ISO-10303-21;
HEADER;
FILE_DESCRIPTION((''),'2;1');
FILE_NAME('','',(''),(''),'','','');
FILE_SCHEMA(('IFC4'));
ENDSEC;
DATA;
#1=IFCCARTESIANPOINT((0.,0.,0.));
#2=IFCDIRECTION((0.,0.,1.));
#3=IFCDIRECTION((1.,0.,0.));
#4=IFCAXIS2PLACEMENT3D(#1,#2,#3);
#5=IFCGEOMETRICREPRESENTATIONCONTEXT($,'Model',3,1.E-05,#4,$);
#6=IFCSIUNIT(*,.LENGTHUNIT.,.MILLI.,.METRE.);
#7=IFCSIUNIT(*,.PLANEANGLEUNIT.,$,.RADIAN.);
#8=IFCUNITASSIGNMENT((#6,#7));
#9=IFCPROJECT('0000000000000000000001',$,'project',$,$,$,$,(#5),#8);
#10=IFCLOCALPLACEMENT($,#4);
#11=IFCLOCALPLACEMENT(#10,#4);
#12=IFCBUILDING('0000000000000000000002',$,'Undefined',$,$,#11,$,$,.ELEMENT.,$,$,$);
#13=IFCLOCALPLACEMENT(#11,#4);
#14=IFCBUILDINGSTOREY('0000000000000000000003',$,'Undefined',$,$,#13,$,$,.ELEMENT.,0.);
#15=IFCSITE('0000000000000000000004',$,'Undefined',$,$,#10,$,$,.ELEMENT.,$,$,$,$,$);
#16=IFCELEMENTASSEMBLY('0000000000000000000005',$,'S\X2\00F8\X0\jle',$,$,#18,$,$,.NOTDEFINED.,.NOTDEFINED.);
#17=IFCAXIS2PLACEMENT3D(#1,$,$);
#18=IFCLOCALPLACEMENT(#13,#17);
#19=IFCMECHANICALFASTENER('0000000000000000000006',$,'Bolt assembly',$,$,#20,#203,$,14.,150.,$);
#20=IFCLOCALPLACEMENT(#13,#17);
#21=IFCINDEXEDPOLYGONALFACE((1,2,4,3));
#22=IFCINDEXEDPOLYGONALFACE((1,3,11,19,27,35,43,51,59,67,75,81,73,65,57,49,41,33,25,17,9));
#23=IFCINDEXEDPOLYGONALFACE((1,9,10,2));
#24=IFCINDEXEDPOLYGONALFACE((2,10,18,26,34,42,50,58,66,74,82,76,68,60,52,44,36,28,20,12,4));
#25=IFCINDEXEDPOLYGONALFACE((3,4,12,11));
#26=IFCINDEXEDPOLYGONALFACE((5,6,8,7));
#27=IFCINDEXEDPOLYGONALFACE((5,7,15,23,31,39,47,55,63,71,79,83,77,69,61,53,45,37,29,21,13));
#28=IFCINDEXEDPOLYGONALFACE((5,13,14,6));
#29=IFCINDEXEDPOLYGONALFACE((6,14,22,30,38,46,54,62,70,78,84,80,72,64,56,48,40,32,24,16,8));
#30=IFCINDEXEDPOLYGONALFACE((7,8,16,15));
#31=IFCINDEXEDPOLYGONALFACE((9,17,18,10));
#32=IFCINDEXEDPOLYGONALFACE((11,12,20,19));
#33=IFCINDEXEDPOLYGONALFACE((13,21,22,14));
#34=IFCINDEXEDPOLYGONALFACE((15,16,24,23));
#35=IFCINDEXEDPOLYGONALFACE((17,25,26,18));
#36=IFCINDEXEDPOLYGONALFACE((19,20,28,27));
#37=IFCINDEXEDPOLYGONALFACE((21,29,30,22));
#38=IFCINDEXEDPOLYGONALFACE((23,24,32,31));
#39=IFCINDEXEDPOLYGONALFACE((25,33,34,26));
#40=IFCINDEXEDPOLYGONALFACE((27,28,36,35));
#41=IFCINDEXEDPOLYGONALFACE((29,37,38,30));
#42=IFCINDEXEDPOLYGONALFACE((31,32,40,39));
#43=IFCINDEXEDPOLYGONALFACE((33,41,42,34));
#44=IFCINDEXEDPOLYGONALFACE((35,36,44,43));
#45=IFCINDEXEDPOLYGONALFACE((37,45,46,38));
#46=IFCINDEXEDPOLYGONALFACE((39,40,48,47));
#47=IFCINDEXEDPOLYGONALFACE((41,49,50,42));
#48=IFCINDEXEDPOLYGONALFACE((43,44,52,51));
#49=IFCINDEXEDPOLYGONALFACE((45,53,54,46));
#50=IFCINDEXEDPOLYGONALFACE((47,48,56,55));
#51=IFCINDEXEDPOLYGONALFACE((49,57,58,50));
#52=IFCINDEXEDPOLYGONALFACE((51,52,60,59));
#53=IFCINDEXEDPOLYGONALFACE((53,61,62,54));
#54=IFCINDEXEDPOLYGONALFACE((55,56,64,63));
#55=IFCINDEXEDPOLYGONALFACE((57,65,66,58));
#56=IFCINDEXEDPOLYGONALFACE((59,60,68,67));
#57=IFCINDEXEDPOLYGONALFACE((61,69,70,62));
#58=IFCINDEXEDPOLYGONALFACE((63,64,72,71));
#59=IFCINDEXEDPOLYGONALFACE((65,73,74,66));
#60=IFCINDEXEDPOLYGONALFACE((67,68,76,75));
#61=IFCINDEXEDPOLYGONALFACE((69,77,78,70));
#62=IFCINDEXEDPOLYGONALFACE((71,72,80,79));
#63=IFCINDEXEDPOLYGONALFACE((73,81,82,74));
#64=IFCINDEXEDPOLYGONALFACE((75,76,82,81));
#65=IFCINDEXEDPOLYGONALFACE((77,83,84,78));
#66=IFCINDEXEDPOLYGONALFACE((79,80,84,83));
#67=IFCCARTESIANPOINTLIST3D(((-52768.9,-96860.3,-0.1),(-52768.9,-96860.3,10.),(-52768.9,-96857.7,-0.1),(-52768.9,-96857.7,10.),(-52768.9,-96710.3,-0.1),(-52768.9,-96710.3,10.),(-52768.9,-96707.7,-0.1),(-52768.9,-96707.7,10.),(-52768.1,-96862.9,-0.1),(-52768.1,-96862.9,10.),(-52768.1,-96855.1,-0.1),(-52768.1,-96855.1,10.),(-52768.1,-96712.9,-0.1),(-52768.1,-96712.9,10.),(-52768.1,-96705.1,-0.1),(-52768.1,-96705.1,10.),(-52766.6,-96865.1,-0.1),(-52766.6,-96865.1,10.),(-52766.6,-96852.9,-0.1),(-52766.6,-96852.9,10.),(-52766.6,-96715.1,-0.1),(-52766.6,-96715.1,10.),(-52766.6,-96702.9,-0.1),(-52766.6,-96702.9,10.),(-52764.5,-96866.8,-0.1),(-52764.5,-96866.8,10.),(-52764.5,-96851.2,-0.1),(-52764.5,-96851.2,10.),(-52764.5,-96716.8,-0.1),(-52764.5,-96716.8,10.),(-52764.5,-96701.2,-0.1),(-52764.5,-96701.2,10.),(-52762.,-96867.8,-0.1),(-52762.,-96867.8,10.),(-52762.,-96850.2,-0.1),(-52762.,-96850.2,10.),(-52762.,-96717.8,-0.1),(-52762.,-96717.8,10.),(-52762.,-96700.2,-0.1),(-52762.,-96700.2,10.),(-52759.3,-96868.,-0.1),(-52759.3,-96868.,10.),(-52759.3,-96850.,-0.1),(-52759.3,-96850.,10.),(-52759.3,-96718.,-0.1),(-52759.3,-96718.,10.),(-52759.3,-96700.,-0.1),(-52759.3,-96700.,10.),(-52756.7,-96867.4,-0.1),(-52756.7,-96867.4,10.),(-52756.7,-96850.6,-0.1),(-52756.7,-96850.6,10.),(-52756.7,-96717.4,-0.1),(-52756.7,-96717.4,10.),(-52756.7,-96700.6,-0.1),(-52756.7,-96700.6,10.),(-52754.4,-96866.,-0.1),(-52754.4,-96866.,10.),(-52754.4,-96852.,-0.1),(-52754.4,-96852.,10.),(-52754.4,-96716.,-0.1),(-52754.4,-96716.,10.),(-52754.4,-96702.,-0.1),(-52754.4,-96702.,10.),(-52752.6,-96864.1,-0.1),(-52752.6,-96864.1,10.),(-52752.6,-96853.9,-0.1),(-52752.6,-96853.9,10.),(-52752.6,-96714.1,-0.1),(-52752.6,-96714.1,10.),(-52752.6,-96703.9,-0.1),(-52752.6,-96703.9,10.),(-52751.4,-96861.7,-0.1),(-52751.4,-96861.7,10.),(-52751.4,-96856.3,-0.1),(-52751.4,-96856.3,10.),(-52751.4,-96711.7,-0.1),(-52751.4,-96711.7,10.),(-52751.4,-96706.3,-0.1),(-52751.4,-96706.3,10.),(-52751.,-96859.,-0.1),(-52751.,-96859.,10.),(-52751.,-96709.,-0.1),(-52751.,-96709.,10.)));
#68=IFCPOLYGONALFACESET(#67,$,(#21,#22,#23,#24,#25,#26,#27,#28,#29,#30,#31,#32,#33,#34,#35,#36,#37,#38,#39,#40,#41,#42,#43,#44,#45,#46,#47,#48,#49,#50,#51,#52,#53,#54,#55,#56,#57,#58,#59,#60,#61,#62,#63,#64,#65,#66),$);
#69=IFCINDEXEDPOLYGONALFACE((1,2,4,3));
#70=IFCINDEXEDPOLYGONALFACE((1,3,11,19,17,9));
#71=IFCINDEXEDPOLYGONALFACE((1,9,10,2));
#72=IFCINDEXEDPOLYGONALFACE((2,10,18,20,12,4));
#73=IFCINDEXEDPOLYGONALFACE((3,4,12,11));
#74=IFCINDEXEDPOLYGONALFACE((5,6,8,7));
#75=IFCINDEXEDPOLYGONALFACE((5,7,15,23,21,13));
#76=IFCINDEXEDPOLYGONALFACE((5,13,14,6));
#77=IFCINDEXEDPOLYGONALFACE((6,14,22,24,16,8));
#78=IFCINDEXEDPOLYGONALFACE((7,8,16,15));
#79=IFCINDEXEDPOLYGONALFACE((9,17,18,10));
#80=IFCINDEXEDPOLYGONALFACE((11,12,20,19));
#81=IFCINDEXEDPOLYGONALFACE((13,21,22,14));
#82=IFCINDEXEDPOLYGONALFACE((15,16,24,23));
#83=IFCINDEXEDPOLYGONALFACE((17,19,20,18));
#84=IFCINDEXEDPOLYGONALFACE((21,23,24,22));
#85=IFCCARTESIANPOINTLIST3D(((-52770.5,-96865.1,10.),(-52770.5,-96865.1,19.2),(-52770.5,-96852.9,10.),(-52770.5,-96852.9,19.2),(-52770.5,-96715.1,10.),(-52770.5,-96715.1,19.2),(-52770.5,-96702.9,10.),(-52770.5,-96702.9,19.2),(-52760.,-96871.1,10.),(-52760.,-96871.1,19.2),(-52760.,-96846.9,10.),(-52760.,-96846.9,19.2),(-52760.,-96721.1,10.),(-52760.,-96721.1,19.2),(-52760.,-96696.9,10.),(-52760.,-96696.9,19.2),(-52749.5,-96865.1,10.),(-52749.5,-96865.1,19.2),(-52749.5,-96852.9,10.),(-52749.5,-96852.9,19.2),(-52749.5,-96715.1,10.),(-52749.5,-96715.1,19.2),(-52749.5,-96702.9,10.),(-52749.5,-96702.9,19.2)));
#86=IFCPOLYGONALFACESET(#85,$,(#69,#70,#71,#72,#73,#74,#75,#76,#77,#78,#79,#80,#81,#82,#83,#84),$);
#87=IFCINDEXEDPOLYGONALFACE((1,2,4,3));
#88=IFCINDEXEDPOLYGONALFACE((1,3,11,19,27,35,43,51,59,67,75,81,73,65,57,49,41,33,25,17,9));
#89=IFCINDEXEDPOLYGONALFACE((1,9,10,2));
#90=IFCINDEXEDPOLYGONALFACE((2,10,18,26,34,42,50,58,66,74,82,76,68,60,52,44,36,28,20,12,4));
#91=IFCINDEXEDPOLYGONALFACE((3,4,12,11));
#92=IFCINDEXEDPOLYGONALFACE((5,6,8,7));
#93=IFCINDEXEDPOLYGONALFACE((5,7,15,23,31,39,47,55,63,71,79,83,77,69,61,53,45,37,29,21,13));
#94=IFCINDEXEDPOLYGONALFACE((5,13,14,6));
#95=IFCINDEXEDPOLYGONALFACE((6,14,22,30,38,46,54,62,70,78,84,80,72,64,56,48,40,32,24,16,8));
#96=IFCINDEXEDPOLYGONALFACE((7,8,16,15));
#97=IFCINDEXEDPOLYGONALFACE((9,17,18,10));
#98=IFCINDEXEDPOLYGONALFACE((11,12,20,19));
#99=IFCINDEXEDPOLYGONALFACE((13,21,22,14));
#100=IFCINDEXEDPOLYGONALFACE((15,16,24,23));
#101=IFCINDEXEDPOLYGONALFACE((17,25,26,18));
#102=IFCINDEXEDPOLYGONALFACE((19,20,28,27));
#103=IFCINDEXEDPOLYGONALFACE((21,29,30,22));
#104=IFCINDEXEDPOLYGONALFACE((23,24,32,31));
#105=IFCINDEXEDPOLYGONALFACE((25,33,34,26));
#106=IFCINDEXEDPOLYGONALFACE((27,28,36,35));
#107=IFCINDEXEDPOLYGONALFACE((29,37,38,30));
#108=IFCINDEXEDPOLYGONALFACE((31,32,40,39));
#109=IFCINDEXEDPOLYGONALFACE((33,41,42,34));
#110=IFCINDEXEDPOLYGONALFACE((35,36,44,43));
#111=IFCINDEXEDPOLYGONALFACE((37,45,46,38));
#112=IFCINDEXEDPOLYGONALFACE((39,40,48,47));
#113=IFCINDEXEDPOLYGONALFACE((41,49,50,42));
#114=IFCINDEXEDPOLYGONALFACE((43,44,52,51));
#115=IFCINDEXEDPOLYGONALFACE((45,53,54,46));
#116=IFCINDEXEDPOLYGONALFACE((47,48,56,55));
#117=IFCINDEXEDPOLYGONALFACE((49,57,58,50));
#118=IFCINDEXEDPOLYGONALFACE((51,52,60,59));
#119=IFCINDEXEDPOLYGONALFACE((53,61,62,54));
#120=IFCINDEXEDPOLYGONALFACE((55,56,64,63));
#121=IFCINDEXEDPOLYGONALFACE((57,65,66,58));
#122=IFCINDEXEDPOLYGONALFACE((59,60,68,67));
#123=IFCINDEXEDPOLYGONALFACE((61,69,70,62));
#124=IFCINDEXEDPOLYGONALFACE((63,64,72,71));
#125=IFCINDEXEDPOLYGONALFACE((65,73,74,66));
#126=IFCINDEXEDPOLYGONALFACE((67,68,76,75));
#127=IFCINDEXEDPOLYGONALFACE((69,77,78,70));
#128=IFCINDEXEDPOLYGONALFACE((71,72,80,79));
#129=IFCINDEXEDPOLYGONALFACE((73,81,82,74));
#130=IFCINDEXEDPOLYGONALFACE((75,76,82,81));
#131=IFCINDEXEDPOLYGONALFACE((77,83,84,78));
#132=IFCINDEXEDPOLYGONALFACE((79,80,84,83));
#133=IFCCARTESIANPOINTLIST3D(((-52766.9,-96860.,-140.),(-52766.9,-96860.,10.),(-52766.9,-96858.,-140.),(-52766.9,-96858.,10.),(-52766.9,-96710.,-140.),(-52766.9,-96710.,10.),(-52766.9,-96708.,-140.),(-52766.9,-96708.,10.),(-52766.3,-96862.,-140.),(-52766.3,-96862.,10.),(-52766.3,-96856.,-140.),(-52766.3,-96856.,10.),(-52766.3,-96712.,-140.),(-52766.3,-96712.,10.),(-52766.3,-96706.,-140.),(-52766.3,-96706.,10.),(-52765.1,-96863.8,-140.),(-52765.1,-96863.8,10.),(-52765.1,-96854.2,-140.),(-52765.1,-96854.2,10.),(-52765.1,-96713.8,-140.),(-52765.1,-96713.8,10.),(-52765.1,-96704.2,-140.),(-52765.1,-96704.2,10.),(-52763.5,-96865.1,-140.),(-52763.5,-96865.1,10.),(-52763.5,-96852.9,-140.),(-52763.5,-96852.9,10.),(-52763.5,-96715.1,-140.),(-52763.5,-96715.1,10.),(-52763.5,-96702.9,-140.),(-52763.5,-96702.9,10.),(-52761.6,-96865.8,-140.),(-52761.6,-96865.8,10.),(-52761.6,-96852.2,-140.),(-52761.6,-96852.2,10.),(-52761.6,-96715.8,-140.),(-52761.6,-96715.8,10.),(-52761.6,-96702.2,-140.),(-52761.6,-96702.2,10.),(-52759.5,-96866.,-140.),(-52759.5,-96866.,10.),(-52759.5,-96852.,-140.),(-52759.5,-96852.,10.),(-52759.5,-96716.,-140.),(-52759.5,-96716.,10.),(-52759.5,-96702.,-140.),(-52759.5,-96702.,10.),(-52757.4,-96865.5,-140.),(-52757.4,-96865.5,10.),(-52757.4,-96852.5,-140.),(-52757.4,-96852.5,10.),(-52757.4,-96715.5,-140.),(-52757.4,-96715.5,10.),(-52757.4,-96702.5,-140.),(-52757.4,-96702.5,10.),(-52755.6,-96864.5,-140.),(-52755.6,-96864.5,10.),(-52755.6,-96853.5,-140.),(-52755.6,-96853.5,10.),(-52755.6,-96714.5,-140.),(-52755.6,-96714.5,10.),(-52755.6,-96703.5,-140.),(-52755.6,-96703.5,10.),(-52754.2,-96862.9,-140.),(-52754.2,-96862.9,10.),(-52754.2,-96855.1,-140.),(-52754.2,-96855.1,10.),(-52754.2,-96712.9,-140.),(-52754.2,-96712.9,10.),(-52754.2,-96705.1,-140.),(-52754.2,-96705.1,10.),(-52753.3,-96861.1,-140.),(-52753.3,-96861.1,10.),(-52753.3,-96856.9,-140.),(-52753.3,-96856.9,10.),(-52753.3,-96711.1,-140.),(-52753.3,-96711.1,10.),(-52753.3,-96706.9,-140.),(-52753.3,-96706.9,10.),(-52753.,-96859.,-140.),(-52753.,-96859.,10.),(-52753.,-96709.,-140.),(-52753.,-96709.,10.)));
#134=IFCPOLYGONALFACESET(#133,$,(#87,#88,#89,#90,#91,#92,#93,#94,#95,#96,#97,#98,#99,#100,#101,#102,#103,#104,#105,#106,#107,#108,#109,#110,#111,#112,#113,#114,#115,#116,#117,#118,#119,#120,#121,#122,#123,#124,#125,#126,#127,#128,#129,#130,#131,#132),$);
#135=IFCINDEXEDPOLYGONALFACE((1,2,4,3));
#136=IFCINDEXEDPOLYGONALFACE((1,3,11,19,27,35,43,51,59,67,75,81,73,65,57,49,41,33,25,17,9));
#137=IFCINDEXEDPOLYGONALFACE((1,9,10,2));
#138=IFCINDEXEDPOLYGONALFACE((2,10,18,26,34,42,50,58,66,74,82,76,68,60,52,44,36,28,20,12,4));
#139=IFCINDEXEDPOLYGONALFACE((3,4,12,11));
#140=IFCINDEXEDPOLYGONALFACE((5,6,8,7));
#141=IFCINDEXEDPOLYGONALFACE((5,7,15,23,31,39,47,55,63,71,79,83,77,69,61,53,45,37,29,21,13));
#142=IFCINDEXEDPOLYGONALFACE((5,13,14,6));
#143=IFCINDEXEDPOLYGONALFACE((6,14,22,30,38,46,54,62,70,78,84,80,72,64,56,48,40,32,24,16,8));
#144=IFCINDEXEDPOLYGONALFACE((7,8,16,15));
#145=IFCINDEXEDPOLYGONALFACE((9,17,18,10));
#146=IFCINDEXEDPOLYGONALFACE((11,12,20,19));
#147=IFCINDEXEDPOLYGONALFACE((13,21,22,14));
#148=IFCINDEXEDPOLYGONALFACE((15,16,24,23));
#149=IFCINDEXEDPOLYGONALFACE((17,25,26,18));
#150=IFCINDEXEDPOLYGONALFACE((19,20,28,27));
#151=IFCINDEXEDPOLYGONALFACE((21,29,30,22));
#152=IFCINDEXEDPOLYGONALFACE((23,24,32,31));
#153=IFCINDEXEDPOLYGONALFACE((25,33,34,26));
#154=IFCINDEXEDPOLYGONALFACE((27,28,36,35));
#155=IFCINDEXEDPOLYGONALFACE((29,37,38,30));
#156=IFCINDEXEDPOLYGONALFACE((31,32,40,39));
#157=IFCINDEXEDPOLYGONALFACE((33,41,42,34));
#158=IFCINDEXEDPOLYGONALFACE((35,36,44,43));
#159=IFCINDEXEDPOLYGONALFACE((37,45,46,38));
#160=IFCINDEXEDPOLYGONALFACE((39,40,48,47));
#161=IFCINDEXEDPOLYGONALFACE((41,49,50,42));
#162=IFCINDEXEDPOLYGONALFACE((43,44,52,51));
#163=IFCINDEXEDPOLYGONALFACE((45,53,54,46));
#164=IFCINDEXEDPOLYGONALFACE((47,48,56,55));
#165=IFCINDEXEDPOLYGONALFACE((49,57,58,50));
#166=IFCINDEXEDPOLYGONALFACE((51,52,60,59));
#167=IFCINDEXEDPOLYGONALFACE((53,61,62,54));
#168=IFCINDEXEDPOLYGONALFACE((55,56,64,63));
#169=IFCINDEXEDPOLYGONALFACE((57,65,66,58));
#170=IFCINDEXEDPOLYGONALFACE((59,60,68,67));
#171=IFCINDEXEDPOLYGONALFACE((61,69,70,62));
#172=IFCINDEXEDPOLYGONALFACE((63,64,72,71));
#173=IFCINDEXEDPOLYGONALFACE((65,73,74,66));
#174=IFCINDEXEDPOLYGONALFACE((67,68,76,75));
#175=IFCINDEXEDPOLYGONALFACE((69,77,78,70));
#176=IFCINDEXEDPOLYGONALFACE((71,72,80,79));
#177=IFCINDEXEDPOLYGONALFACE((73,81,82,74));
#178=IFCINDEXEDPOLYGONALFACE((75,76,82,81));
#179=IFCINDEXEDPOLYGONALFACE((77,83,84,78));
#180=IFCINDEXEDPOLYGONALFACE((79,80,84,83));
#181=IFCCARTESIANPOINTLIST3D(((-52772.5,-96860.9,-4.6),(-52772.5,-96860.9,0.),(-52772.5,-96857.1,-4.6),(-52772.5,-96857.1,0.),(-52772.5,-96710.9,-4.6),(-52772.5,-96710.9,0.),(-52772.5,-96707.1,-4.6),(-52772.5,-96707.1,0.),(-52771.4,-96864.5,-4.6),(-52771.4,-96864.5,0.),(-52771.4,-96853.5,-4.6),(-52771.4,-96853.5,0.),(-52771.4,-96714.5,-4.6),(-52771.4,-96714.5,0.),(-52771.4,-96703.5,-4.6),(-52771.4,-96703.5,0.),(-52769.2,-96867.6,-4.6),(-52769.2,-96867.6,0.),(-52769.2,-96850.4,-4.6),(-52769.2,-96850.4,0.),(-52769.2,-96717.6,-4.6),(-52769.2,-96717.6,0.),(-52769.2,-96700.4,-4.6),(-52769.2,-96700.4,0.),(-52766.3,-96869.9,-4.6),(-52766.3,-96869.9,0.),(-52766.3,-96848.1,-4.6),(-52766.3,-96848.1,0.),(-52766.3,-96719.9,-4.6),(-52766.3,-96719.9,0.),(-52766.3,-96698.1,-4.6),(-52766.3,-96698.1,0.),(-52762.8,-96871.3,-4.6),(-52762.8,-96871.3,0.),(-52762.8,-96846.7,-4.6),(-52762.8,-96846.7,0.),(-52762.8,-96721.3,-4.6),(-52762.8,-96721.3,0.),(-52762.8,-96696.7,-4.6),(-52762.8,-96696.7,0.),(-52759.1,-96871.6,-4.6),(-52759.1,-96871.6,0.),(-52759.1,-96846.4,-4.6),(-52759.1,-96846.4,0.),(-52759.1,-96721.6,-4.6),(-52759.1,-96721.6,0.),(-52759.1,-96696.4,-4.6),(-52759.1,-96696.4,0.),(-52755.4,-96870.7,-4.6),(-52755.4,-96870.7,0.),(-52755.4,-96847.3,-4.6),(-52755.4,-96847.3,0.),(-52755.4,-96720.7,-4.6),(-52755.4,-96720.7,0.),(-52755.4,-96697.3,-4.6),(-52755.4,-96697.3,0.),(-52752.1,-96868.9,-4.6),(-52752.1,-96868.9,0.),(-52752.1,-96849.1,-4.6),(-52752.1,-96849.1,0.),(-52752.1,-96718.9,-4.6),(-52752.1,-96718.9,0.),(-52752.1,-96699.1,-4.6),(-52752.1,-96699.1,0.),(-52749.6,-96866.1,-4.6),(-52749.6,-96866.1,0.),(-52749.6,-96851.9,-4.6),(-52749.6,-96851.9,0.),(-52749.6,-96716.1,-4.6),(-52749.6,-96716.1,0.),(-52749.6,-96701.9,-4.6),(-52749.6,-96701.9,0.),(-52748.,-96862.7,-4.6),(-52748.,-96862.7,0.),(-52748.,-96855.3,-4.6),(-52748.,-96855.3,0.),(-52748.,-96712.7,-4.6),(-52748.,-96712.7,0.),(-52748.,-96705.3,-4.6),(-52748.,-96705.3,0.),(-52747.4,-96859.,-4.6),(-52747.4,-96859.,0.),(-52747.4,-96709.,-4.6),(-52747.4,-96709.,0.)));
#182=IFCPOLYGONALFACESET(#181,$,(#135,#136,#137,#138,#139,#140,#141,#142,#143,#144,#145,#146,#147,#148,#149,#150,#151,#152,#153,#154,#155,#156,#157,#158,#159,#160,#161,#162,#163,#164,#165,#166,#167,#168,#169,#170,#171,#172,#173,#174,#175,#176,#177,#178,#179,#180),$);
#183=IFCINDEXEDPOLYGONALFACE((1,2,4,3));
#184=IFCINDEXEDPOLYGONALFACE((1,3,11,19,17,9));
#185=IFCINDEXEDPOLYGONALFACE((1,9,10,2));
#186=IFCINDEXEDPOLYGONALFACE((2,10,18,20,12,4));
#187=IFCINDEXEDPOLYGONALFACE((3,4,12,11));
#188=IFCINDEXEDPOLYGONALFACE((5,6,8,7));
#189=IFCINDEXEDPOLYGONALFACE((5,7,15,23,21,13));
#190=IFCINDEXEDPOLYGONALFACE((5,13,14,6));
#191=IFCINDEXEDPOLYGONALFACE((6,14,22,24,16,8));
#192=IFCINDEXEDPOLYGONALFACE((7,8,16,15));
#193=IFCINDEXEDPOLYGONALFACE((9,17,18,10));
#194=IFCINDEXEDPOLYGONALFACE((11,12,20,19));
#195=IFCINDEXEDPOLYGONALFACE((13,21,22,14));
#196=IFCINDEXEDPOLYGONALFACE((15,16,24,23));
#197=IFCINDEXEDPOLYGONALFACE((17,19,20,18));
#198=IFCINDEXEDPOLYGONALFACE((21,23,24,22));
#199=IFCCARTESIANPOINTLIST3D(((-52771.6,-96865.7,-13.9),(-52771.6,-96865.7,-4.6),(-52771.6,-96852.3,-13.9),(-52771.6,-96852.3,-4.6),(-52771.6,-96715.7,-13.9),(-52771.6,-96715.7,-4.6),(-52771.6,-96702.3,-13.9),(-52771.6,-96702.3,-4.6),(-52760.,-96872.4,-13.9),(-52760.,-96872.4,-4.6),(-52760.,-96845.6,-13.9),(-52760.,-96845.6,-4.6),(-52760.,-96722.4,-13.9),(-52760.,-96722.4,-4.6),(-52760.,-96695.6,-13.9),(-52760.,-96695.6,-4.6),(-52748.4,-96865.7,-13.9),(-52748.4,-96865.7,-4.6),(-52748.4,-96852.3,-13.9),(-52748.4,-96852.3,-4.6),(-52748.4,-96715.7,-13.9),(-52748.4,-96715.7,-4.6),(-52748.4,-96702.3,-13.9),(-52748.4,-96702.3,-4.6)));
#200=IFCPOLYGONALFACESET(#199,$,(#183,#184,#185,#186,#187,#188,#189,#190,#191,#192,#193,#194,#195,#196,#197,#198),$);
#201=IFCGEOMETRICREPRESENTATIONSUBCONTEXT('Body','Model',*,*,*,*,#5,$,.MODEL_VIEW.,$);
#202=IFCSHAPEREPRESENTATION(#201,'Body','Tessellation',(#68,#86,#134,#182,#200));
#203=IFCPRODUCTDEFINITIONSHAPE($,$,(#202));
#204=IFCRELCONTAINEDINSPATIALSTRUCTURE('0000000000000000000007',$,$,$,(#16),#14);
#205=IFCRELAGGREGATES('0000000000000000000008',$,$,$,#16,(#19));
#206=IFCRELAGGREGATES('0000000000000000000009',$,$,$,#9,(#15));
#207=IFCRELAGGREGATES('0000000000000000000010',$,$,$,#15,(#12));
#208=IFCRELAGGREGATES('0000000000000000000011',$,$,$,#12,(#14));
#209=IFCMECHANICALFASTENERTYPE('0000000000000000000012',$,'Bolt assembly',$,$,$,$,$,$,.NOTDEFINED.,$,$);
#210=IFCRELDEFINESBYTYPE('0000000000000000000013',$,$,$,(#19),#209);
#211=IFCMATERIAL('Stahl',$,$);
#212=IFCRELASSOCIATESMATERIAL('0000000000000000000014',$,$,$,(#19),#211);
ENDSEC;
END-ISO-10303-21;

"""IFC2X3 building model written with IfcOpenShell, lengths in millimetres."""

from ifc_helpers import new_model, si_unit, frame, origin_with_axes, origin_2d_with_axis, place, context, subcontext, project, spatial, polyline, circle, outline, extrude, source, transform, mapped, material, type_object, element, aggregate, save


model = new_model("IFC2X3")

# Units and contexts
model_context = context("Model", 3, precision=1e-05, world=origin_with_axes())
body_context = subcontext(model_context, "Body", "Model", "MODEL_VIEW")
ifc_project = project(units=[si_unit("LENGTHUNIT", "METRE", prefix="MILLI"), si_unit("PLANEANGLEUNIT", "RADIAN")], contexts=[model_context])

# Site, building, storey
site_placement = place(None, origin_with_axes())
site = spatial("IfcSite", under=ifc_project, at=site_placement, Name="Undefined", CompositionType="ELEMENT")
building_placement = place(site_placement, origin_with_axes())
building = spatial("IfcBuilding", under=site, at=building_placement, Name="Undefined", CompositionType="ELEMENT")
storey_placement = place(building_placement, origin_with_axes())
storey = spatial("IfcBuildingStorey", under=building, at=storey_placement, Name="Undefined", CompositionType="ELEMENT", Elevation=0.0)

# Element assembly
assembly_1_placement = place(storey_placement, origin_with_axes())
assembly_1 = element("IfcElementAssembly", 1, at=assembly_1_placement, inside=storey, Name="Søjle", AssemblyPlace="NOTDEFINED", PredefinedType="NOTDEFINED")

# Shared definitions
mechanical_fastener_type = type_object("IfcMechanicalFastenerType", Name="Bolt assembly")

# Mechanical fastener
ifc_material_1 = material(Name="Stahl")
shared_shape_1 = source(origin_with_axes(), body_context, "Body", "SweptSolid", [
    extrude(circle(Radius=9.0, at=origin_2d_with_axis()), frame((0.0, 0.0, 0.0), z_axis=(0.0, 1.0, 0.0), x_axis=(1.0, 0.0, 0.0)), (0.0, 0.0, 1.0), 10.1),
    extrude(outline(polyline([(10.5, -6.1), (10.5, 6.1), (0.0, 12.1), (-10.5, 6.1), (-10.5, -6.1), (0.0, -12.1), (10.5, -6.1)])), frame((0.0, -9.2, 0.0), z_axis=(0.0, 1.0, 0.0), x_axis=(1.0, 0.0, 0.0)), (0.0, 0.0, 1.0), 9.2),
    extrude(circle(Radius=7.0, at=origin_2d_with_axis()), frame((0.0, 0.0, 0.0), z_axis=(0.0, 1.0, 0.0), x_axis=(1.0, 0.0, 0.0)), (0.0, 0.0, 1.0), 150.0),
    extrude(circle(Radius=12.6, at=origin_2d_with_axis()), frame((0.0, 10.0, 0.0), z_axis=(0.0, 1.0, 0.0), x_axis=(1.0, 0.0, 0.0)), (0.0, 0.0, 1.0), 4.6),
    extrude(outline(polyline([(11.6, -6.7), (11.6, 6.7), (0.0, 13.4), (-11.6, 6.7), (-11.6, -6.7), (0.0, -13.4), (11.6, -6.7)])), frame((0.0, 14.6, 0.0), z_axis=(0.0, 1.0, 0.0), x_axis=(1.0, 0.0, 0.0)), (0.0, 0.0, 1.0), 9.2),
])
mechanical_fastener_1_placement = place(assembly_1_placement, frame((-52760.0, -96784.0, 10.0), z_axis=(0.0, 1.0, 0.0), x_axis=(1.0, 0.0, 0.0)))
mechanical_fastener_1 = element("IfcMechanicalFastener", 2, at=mechanical_fastener_1_placement, type_object=mechanical_fastener_type, material=ifc_material_1, Name="Bolt assembly", NominalDiameter=14.0, NominalLength=150.0, context=body_context, shape_type="MappedRepresentation", body=[
    mapped(shared_shape_1, transform((0.0, 0.0, -75.0))),
    mapped(shared_shape_1, transform((0.0, 0.0, 75.0))),
])
aggregate(assembly_1, [mechanical_fastener_1])

save(model, "model.ifc")
